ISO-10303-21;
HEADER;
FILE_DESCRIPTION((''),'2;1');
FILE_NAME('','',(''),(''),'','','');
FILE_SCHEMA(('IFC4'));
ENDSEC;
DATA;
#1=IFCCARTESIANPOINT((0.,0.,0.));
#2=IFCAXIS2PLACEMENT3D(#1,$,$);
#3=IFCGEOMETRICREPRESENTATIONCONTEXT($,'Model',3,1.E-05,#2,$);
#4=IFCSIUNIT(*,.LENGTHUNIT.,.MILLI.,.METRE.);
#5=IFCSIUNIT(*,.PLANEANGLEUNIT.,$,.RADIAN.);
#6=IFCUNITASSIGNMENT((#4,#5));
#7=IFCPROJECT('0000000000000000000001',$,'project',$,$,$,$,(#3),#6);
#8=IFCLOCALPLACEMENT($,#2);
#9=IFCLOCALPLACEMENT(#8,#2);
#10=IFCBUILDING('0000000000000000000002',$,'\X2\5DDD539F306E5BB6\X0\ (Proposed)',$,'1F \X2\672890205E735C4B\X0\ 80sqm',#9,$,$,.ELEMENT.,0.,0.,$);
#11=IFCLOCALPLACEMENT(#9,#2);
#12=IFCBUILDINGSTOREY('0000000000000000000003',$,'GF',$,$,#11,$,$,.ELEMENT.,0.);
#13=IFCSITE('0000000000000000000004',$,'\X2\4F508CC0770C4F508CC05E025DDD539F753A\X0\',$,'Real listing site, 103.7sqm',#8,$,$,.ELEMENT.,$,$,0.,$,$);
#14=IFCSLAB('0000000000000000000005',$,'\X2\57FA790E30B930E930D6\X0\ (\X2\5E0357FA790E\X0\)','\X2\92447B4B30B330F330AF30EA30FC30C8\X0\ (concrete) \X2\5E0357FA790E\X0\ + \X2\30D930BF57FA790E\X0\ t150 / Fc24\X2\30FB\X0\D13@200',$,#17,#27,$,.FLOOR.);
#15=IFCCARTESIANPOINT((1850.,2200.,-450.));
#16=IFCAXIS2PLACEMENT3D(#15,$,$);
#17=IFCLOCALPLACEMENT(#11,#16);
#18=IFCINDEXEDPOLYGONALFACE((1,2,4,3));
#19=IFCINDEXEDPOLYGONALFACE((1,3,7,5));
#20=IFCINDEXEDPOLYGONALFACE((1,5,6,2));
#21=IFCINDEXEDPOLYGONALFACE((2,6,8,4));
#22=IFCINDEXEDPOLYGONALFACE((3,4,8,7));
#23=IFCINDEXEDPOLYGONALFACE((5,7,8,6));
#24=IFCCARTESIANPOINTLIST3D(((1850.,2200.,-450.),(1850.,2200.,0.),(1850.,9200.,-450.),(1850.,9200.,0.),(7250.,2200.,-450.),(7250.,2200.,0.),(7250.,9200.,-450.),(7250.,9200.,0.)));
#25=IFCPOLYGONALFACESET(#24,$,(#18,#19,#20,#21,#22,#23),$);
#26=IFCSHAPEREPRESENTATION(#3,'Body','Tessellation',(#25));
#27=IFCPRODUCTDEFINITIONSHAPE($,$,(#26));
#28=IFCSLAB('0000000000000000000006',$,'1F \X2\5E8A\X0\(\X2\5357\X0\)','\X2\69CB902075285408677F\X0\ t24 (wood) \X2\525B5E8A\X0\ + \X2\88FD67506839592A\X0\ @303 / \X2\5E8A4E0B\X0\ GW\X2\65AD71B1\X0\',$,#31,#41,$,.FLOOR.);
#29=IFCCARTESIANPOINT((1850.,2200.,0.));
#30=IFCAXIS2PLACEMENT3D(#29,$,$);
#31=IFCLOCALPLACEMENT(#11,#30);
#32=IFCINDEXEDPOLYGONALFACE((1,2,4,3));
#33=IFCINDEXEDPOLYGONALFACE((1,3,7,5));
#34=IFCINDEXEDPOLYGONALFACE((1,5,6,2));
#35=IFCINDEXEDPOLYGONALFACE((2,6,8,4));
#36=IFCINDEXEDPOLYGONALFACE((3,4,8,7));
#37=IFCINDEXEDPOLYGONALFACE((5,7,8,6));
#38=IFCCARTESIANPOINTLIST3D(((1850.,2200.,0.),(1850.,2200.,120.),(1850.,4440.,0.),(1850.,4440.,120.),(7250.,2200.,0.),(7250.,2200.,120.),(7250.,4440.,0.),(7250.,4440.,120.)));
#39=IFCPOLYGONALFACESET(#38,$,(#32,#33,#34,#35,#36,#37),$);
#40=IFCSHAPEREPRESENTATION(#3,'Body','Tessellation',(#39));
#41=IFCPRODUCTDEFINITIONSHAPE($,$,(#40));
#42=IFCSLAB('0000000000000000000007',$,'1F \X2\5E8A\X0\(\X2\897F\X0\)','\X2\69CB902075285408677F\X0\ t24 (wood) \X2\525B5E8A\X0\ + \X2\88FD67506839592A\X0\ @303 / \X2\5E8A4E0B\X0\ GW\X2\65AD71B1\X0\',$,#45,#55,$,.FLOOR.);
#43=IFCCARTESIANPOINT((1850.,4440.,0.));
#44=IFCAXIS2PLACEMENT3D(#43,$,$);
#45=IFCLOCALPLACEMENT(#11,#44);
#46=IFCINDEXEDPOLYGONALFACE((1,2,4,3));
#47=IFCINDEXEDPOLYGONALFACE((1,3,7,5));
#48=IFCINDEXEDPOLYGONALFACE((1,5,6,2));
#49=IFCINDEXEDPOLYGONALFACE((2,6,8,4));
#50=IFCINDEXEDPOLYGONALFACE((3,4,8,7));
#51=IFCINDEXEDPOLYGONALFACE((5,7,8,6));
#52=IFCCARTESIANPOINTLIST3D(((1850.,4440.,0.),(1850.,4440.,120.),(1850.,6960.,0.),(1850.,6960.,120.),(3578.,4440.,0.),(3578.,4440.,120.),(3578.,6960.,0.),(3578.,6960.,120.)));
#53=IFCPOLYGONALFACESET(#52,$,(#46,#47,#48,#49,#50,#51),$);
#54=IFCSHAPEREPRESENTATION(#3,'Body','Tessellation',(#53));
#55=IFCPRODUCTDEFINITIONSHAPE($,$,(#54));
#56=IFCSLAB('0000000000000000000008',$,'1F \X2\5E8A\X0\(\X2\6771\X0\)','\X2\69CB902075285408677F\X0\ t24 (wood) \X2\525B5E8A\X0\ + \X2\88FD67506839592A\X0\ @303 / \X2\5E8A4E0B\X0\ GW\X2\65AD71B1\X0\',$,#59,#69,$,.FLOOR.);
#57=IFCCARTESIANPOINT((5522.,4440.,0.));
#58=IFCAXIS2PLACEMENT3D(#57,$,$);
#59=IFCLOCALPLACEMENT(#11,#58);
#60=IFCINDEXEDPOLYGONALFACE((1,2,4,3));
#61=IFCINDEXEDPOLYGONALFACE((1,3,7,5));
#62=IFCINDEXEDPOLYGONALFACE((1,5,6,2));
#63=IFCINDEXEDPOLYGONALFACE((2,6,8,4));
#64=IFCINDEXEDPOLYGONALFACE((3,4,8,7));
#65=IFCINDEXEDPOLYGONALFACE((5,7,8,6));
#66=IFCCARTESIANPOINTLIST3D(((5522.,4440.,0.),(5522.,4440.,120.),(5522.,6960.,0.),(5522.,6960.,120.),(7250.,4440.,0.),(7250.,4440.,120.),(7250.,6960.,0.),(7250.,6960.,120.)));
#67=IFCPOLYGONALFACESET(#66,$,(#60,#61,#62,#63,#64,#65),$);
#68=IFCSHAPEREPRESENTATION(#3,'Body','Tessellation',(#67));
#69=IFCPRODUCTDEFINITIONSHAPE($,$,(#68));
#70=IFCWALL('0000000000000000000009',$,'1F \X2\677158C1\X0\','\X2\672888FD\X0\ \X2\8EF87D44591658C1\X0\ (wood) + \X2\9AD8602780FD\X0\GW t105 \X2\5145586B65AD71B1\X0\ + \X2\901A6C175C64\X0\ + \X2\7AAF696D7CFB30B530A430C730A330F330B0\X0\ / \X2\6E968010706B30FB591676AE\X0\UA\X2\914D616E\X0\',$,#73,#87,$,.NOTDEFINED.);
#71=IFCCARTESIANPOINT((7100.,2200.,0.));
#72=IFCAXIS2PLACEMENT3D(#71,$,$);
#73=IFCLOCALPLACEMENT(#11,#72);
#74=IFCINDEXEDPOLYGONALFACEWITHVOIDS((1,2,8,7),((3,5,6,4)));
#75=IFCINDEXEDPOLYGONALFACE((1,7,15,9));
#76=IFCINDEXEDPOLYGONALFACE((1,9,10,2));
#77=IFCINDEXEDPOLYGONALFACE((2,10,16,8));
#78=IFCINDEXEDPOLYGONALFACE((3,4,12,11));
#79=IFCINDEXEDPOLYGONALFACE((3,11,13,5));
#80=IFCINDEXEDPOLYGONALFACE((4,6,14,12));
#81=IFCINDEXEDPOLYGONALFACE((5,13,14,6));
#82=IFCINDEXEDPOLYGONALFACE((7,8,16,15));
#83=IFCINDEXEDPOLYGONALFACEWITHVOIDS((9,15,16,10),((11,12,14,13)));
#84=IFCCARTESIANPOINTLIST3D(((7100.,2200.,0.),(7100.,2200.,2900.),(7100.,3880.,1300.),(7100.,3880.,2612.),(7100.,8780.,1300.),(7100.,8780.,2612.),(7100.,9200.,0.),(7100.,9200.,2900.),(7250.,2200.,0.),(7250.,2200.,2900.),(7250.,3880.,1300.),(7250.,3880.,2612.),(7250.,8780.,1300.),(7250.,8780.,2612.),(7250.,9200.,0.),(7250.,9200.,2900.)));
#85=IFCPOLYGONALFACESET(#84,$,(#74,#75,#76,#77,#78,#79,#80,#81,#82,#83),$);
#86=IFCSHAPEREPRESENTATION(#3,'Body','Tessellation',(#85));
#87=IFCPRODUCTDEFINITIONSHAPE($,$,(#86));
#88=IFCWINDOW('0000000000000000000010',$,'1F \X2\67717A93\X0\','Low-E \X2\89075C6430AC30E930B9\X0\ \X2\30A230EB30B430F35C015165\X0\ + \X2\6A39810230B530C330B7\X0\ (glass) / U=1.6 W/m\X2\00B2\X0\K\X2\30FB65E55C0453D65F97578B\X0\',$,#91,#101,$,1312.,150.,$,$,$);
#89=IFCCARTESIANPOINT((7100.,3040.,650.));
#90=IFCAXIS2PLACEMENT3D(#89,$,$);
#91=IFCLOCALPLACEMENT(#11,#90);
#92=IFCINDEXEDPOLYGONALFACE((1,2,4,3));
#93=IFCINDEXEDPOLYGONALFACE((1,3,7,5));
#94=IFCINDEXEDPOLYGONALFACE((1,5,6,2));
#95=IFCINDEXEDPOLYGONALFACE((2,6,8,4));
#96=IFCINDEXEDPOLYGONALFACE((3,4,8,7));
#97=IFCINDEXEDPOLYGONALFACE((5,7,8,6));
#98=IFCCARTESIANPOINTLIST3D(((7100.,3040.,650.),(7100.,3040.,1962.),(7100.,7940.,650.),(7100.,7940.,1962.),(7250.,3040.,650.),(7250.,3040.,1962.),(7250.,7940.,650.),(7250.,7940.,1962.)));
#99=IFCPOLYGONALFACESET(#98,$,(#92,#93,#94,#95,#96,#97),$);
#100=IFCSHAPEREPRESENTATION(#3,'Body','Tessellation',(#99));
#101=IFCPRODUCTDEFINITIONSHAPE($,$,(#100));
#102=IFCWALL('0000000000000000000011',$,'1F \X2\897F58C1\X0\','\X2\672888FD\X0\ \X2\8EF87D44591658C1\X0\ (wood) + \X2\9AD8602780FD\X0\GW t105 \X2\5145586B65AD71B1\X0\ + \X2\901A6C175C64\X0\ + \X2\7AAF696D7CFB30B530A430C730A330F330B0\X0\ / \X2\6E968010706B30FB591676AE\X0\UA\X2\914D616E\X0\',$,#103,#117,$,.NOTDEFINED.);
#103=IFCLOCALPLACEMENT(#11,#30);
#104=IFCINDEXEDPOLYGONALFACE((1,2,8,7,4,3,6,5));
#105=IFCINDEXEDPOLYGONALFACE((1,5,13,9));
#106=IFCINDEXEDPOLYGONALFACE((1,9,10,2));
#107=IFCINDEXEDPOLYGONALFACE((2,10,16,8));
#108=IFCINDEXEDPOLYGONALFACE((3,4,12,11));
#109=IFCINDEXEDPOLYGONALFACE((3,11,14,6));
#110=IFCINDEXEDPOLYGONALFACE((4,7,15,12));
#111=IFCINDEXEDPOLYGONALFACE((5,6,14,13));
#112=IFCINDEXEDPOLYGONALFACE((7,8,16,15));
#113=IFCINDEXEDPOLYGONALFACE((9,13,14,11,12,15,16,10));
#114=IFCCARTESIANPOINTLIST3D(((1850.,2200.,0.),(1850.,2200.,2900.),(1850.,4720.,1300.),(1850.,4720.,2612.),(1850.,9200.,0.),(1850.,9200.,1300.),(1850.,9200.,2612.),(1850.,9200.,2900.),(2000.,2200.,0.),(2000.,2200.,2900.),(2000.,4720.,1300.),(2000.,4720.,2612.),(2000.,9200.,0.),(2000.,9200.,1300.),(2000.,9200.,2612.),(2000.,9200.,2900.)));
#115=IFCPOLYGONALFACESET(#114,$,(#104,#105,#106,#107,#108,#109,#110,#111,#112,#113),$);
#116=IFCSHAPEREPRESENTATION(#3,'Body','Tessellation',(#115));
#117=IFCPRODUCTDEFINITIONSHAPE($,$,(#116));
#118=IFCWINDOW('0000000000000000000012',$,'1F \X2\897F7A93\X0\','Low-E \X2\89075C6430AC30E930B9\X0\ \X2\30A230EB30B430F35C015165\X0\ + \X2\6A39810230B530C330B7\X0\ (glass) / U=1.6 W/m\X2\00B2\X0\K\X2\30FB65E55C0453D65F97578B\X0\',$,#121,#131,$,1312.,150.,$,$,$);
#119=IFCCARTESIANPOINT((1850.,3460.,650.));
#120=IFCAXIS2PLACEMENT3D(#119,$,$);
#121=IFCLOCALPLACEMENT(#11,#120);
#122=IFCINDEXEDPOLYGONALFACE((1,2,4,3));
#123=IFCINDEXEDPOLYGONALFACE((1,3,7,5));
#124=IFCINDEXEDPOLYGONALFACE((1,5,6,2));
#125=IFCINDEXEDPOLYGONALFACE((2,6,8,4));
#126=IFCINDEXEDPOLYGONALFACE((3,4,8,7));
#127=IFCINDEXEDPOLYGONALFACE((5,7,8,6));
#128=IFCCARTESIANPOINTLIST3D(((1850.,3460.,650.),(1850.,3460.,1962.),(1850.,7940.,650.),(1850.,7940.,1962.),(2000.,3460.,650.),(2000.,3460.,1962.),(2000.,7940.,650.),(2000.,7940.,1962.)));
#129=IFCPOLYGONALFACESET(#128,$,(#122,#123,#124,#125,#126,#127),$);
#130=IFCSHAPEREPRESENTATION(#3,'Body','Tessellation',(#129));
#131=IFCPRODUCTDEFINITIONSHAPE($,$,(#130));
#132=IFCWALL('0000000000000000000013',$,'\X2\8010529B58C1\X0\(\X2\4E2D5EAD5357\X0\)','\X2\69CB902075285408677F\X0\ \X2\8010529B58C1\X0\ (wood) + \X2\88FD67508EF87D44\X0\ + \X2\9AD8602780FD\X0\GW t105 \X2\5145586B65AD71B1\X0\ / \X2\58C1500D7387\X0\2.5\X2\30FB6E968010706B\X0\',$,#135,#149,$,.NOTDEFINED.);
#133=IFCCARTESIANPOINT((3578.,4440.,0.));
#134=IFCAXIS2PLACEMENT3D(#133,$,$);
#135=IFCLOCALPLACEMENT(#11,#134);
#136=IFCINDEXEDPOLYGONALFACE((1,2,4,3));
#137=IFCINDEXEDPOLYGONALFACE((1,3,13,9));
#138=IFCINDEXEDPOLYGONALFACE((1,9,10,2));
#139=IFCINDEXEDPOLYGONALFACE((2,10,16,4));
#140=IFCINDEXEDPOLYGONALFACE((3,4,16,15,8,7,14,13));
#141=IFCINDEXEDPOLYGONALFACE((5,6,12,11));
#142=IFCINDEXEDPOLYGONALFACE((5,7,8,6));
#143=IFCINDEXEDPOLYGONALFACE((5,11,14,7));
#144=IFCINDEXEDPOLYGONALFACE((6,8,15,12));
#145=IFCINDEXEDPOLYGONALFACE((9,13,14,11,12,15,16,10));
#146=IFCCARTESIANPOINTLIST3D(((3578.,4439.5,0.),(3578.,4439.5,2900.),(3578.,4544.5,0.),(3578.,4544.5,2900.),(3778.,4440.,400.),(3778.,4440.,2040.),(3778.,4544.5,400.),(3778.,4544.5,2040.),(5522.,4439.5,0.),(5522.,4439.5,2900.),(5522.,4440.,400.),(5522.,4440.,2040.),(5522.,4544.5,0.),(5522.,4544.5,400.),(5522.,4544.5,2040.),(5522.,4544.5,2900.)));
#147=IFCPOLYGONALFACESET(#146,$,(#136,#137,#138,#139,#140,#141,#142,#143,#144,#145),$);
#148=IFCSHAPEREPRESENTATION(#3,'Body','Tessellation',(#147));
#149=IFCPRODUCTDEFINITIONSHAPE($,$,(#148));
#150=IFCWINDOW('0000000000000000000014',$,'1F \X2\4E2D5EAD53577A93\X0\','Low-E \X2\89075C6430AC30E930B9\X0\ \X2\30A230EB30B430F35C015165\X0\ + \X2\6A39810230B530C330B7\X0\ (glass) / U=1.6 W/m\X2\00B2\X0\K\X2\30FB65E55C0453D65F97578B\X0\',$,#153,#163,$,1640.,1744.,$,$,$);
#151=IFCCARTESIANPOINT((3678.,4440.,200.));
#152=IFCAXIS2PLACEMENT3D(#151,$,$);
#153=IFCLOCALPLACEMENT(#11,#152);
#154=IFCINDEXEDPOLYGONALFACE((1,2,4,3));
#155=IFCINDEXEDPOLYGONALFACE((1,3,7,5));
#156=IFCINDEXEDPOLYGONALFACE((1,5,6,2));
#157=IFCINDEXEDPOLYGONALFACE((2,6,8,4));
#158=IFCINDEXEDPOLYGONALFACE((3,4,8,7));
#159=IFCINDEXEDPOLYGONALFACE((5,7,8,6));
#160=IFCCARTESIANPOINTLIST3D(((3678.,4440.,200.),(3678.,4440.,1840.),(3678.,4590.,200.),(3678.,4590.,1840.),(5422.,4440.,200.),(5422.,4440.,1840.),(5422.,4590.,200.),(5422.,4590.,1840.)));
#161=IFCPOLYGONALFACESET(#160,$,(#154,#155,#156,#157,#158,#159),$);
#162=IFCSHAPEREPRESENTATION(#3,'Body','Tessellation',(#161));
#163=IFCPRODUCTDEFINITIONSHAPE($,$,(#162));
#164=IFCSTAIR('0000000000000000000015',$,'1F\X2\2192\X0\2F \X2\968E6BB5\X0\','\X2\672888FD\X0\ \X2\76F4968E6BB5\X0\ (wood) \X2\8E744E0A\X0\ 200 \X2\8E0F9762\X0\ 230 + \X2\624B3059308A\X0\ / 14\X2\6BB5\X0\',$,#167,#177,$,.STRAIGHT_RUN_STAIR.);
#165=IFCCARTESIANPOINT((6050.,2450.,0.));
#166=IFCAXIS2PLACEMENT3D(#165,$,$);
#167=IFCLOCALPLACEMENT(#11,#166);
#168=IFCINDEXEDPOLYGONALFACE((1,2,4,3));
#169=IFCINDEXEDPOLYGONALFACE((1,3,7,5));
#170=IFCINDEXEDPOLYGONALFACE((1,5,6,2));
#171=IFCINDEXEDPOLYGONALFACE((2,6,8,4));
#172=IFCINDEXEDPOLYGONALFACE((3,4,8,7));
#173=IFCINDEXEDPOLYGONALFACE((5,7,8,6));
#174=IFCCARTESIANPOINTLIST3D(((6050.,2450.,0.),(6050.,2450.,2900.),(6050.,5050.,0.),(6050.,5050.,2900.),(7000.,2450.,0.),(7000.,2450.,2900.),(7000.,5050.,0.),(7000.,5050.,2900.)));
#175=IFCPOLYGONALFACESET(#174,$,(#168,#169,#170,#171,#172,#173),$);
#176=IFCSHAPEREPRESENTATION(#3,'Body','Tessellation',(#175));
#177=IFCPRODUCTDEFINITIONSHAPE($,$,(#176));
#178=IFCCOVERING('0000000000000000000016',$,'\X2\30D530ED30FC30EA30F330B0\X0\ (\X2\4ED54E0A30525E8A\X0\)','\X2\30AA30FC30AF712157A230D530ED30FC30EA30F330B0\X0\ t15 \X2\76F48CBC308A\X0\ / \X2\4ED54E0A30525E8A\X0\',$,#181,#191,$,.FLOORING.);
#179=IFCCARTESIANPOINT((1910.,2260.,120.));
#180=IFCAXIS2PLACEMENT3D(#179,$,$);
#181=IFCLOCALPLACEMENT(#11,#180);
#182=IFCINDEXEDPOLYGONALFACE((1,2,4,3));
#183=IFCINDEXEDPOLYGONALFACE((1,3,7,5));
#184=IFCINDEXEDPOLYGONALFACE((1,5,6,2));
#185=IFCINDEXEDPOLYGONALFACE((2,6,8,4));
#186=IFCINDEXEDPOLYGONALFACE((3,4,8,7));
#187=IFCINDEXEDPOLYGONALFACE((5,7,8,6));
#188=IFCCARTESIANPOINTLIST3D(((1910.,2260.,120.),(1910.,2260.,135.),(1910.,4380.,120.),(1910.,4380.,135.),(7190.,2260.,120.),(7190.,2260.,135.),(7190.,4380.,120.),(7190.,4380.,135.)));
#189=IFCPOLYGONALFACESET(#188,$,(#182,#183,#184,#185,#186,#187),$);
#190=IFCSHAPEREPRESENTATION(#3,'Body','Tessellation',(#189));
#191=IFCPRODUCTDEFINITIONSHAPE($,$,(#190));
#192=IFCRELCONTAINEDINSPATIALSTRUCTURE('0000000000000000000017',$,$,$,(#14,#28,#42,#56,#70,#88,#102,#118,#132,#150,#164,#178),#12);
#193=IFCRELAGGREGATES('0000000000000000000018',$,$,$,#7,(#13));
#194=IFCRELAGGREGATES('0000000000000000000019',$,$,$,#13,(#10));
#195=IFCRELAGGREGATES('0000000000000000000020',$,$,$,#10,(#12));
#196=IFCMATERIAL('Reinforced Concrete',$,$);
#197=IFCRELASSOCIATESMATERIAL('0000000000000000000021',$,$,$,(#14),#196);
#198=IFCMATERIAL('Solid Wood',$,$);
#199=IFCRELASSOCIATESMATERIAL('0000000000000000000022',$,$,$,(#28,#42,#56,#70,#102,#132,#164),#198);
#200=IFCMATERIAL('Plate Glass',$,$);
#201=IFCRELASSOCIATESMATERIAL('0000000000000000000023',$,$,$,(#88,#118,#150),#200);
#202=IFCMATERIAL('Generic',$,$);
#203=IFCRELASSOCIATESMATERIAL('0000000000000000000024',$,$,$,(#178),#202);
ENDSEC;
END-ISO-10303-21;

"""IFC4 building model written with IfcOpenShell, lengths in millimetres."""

from ifc_helpers import new_model, si_unit, frame, frame_2d, origin, place, context, project, spatial, rectangle, extrude, material, element, fill, save


model = new_model("IFC4")

# Units and contexts
model_context = context("Model", 3, precision=1e-05, world=origin())
ifc_project = project(units=[si_unit("LENGTHUNIT", "METRE", prefix="MILLI"), si_unit("PLANEANGLEUNIT", "RADIAN")], contexts=[model_context])

# Site, building, storey
site_placement = place(None, origin())
site = spatial("IfcSite", under=ifc_project, at=site_placement, Name="佐賀県佐賀市川原町", ObjectType="Real listing site, 103.7sqm", CompositionType="ELEMENT", RefElevation=0.0)
building_placement = place(site_placement, origin())
building = spatial("IfcBuilding", under=site, at=building_placement, Name="川原の家 (Proposed)", ObjectType="1F 木造平屋 80sqm", CompositionType="ELEMENT", ElevationOfRefHeight=0.0, ElevationOfTerrain=0.0)
storey_placement = place(building_placement, origin())
storey = spatial("IfcBuildingStorey", under=building, at=storey_placement, Name="GF", CompositionType="ELEMENT", Elevation=0.0)

# Slabs
ifc_material_1 = material(Name="Reinforced Concrete")
slab_1_placement = place(storey_placement, frame((1850.0, 2200.0, -450.0)))
element("IfcSlab", 1, at=slab_1_placement, inside=storey, material=ifc_material_1, Name="基礎スラブ (布基礎)", Description="鉄筋コンクリート (concrete) 布基礎 + ベタ基礎 t150 / Fc24・D13@200", PredefinedType="FLOOR", context=model_context, shape_type="SweptSolid", body=[
    extrude(rectangle(XDim=5400.0, YDim=7000.0, at=frame_2d((2700.0, 3500.0))), frame((1850.0, 2200.0, -450.0)), (0.0, 0.0, 1.0), 450.0),
])
ifc_material_2 = material(Name="Solid Wood")
slab_2_placement = place(storey_placement, frame((1850.0, 2200.0, 0.0)))
element("IfcSlab", 2, at=slab_2_placement, inside=storey, material=ifc_material_2, Name="1F 床(南)", Description="構造用合板 t24 (wood) 剛床 + 製材根太 @303 / 床下 GW断熱", PredefinedType="FLOOR", context=model_context, shape_type="SweptSolid", body=[
    extrude(rectangle(XDim=5400.0, YDim=2240.0, at=frame_2d((2700.0, 1120.0))), frame((1850.0, 2200.0, 0.0)), (0.0, 0.0, 1.0), 120.0),
])
slab_3_placement = place(storey_placement, frame((1850.0, 4440.0, 0.0)))
element("IfcSlab", 3, at=slab_3_placement, inside=storey, material=ifc_material_2, Name="1F 床(西)", Description="構造用合板 t24 (wood) 剛床 + 製材根太 @303 / 床下 GW断熱", PredefinedType="FLOOR", context=model_context, shape_type="SweptSolid", body=[
    extrude(rectangle(XDim=1728.0, YDim=2520.0, at=frame_2d((864.0, 1260.0))), frame((1850.0, 4440.0, 0.0)), (0.0, 0.0, 1.0), 120.0),
])
slab_4_placement = place(storey_placement, frame((5522.0, 4440.0, 0.0)))
element("IfcSlab", 4, at=slab_4_placement, inside=storey, material=ifc_material_2, Name="1F 床(東)", Description="構造用合板 t24 (wood) 剛床 + 製材根太 @303 / 床下 GW断熱", PredefinedType="FLOOR", context=model_context, shape_type="SweptSolid", body=[
    extrude(rectangle(XDim=1728.0, YDim=2520.0, at=frame_2d((864.0, 1260.0))), frame((5522.0, 4440.0, 0.0)), (0.0, 0.0, 1.0), 120.0),
])

# Shared definitions
ifc_material_3 = material(Name="Plate Glass")

# Walls, openings, windows
wall_1_placement = place(storey_placement, frame((7100.0, 2200.0, 0.0)))
wall_1 = element("IfcWall", 5, at=wall_1_placement, inside=storey, material=ifc_material_2, Name="1F 東壁", Description="木製 軸組外壁 (wood) + 高性能GW t105 充填断熱 + 通気層 + 窯業系サイディング / 準耐火・外皮UA配慮", PredefinedType="NOTDEFINED", context=model_context, shape_type="SweptSolid", body=[
    extrude(rectangle(XDim=150.0, YDim=7000.0, at=frame_2d((75.0, 3500.0))), frame((7100.0, 2200.0, 0.0)), (0.0, 0.0, 1.0), 2900.0),
])
opening_1_placement = place(storey_placement, frame((7100.0, 3040.0, 650.0)))
opening_1 = element("IfcOpeningElement", 6, at=opening_1_placement, cuts=wall_1, PredefinedType="NOTDEFINED", context=model_context, shape_type="SweptSolid", body=[
    extrude(rectangle(XDim=150.0, YDim=4900.0, at=frame_2d((75.0, 2450.0))), frame((7100.0, 3040.0, 650.0)), (0.0, 0.0, 1.0), 1312.0),
])
window_1_placement = place(storey_placement, frame((7100.0, 3040.0, 650.0)))
window_1 = element("IfcWindow", 7, at=window_1_placement, inside=storey, material=ifc_material_3, Name="1F 東窓", Description="Low-E 複層ガラス アルゴン封入 + 樹脂サッシ (glass) / U=1.6 W/m²K・日射取得型", OverallHeight=1312.0, OverallWidth=150.0, context=model_context, shape_type="SweptSolid", body=[
    extrude(rectangle(XDim=150.0, YDim=4900.0, at=frame_2d((75.0, 2450.0))), frame((7100.0, 3040.0, 650.0)), (0.0, 0.0, 1.0), 1312.0),
])
fill(opening_1, window_1)
wall_2_placement = place(storey_placement, frame((1850.0, 2200.0, 0.0)))
wall_2 = element("IfcWall", 8, at=wall_2_placement, inside=storey, material=ifc_material_2, Name="1F 西壁", Description="木製 軸組外壁 (wood) + 高性能GW t105 充填断熱 + 通気層 + 窯業系サイディング / 準耐火・外皮UA配慮", PredefinedType="NOTDEFINED", context=model_context, shape_type="SweptSolid", body=[
    extrude(rectangle(XDim=150.0, YDim=7000.0, at=frame_2d((75.0, 3500.0))), frame((1850.0, 2200.0, 0.0)), (0.0, 0.0, 1.0), 2900.0),
])
opening_2_placement = place(storey_placement, frame((1850.0, 3460.0, 650.0)))
opening_2 = element("IfcOpeningElement", 9, at=opening_2_placement, cuts=wall_2, PredefinedType="NOTDEFINED", context=model_context, shape_type="SweptSolid", body=[
    extrude(rectangle(XDim=150.0, YDim=4480.0, at=frame_2d((75.0, 2240.0))), frame((1850.0, 3460.0, 650.0)), (0.0, 0.0, 1.0), 1312.0),
])
window_2_placement = place(storey_placement, frame((1850.0, 3460.0, 650.0)))
window_2 = element("IfcWindow", 10, at=window_2_placement, inside=storey, material=ifc_material_3, Name="1F 西窓", Description="Low-E 複層ガラス アルゴン封入 + 樹脂サッシ (glass) / U=1.6 W/m²K・日射取得型", OverallHeight=1312.0, OverallWidth=150.0, context=model_context, shape_type="SweptSolid", body=[
    extrude(rectangle(XDim=150.0, YDim=4480.0, at=frame_2d((75.0, 2240.0))), frame((1850.0, 3460.0, 650.0)), (0.0, 0.0, 1.0), 1312.0),
])
fill(opening_2, window_2)
wall_3_placement = place(storey_placement, frame((3578.0, 4440.0, 0.0)))
wall_3 = element("IfcWall", 11, at=wall_3_placement, inside=storey, material=ifc_material_2, Name="耐力壁(中庭南)", Description="構造用合板 耐力壁 (wood) + 製材軸組 + 高性能GW t105 充填断熱 / 壁倍率2.5・準耐火", PredefinedType="NOTDEFINED", context=model_context, shape_type="SweptSolid", body=[
    extrude(rectangle(XDim=1944.0, YDim=105.0, at=frame_2d((972.0, 52.0))), frame((3578.0, 4440.0, 0.0)), (0.0, 0.0, 1.0), 2900.0),
])
opening_3_placement = place(storey_placement, frame((3678.0, 4440.0, 200.0)))
opening_3 = element("IfcOpeningElement", 12, at=opening_3_placement, cuts=wall_3, PredefinedType="NOTDEFINED", context=model_context, shape_type="SweptSolid", body=[
    extrude(rectangle(XDim=1744.0, YDim=150.0, at=frame_2d((872.0, 75.0))), frame((3678.0, 4440.0, 200.0)), (0.0, 0.0, 1.0), 1640.0),
])
window_3_placement = place(storey_placement, frame((3678.0, 4440.0, 200.0)))
window_3 = element("IfcWindow", 13, at=window_3_placement, inside=storey, material=ifc_material_3, Name="1F 中庭南窓", Description="Low-E 複層ガラス アルゴン封入 + 樹脂サッシ (glass) / U=1.6 W/m²K・日射取得型", OverallHeight=1640.0, OverallWidth=1744.0, context=model_context, shape_type="SweptSolid", body=[
    extrude(rectangle(XDim=1744.0, YDim=150.0, at=frame_2d((872.0, 75.0))), frame((3678.0, 4440.0, 200.0)), (0.0, 0.0, 1.0), 1640.0),
])
fill(opening_3, window_3)

# Stair
stair_placement = place(storey_placement, frame((6050.0, 2450.0, 0.0)))
element("IfcStair", 14, at=stair_placement, inside=storey, material=ifc_material_2, Name="1F→2F 階段", Description="木製 直階段 (wood) 蹴上 200 踏面 230 + 手すり / 14段", PredefinedType="STRAIGHT_RUN_STAIR", context=model_context, shape_type="SweptSolid", body=[
    extrude(rectangle(XDim=950.0, YDim=2600.0, at=frame_2d((475.0, 1300.0))), frame((6050.0, 2450.0, 0.0)), (0.0, 0.0, 1.0), 2900.0),
])

# Covering
ifc_material_4 = material(Name="Generic")
covering_placement = place(storey_placement, frame((1910.0, 2260.0, 120.0)))
element("IfcCovering", 15, at=covering_placement, inside=storey, material=ifc_material_4, Name="フローリング (仕上げ床)", Description="オーク無垢フローリング t15 直貼り / 仕上げ床", PredefinedType="FLOORING", context=model_context, shape_type="SweptSolid", body=[
    extrude(rectangle(XDim=5280.0, YDim=2120.0, at=frame_2d((2640.0, 1060.0))), frame((1910.0, 2260.0, 120.0)), (0.0, 0.0, 1.0), 15.0),
])

save(model, "model.ifc")
